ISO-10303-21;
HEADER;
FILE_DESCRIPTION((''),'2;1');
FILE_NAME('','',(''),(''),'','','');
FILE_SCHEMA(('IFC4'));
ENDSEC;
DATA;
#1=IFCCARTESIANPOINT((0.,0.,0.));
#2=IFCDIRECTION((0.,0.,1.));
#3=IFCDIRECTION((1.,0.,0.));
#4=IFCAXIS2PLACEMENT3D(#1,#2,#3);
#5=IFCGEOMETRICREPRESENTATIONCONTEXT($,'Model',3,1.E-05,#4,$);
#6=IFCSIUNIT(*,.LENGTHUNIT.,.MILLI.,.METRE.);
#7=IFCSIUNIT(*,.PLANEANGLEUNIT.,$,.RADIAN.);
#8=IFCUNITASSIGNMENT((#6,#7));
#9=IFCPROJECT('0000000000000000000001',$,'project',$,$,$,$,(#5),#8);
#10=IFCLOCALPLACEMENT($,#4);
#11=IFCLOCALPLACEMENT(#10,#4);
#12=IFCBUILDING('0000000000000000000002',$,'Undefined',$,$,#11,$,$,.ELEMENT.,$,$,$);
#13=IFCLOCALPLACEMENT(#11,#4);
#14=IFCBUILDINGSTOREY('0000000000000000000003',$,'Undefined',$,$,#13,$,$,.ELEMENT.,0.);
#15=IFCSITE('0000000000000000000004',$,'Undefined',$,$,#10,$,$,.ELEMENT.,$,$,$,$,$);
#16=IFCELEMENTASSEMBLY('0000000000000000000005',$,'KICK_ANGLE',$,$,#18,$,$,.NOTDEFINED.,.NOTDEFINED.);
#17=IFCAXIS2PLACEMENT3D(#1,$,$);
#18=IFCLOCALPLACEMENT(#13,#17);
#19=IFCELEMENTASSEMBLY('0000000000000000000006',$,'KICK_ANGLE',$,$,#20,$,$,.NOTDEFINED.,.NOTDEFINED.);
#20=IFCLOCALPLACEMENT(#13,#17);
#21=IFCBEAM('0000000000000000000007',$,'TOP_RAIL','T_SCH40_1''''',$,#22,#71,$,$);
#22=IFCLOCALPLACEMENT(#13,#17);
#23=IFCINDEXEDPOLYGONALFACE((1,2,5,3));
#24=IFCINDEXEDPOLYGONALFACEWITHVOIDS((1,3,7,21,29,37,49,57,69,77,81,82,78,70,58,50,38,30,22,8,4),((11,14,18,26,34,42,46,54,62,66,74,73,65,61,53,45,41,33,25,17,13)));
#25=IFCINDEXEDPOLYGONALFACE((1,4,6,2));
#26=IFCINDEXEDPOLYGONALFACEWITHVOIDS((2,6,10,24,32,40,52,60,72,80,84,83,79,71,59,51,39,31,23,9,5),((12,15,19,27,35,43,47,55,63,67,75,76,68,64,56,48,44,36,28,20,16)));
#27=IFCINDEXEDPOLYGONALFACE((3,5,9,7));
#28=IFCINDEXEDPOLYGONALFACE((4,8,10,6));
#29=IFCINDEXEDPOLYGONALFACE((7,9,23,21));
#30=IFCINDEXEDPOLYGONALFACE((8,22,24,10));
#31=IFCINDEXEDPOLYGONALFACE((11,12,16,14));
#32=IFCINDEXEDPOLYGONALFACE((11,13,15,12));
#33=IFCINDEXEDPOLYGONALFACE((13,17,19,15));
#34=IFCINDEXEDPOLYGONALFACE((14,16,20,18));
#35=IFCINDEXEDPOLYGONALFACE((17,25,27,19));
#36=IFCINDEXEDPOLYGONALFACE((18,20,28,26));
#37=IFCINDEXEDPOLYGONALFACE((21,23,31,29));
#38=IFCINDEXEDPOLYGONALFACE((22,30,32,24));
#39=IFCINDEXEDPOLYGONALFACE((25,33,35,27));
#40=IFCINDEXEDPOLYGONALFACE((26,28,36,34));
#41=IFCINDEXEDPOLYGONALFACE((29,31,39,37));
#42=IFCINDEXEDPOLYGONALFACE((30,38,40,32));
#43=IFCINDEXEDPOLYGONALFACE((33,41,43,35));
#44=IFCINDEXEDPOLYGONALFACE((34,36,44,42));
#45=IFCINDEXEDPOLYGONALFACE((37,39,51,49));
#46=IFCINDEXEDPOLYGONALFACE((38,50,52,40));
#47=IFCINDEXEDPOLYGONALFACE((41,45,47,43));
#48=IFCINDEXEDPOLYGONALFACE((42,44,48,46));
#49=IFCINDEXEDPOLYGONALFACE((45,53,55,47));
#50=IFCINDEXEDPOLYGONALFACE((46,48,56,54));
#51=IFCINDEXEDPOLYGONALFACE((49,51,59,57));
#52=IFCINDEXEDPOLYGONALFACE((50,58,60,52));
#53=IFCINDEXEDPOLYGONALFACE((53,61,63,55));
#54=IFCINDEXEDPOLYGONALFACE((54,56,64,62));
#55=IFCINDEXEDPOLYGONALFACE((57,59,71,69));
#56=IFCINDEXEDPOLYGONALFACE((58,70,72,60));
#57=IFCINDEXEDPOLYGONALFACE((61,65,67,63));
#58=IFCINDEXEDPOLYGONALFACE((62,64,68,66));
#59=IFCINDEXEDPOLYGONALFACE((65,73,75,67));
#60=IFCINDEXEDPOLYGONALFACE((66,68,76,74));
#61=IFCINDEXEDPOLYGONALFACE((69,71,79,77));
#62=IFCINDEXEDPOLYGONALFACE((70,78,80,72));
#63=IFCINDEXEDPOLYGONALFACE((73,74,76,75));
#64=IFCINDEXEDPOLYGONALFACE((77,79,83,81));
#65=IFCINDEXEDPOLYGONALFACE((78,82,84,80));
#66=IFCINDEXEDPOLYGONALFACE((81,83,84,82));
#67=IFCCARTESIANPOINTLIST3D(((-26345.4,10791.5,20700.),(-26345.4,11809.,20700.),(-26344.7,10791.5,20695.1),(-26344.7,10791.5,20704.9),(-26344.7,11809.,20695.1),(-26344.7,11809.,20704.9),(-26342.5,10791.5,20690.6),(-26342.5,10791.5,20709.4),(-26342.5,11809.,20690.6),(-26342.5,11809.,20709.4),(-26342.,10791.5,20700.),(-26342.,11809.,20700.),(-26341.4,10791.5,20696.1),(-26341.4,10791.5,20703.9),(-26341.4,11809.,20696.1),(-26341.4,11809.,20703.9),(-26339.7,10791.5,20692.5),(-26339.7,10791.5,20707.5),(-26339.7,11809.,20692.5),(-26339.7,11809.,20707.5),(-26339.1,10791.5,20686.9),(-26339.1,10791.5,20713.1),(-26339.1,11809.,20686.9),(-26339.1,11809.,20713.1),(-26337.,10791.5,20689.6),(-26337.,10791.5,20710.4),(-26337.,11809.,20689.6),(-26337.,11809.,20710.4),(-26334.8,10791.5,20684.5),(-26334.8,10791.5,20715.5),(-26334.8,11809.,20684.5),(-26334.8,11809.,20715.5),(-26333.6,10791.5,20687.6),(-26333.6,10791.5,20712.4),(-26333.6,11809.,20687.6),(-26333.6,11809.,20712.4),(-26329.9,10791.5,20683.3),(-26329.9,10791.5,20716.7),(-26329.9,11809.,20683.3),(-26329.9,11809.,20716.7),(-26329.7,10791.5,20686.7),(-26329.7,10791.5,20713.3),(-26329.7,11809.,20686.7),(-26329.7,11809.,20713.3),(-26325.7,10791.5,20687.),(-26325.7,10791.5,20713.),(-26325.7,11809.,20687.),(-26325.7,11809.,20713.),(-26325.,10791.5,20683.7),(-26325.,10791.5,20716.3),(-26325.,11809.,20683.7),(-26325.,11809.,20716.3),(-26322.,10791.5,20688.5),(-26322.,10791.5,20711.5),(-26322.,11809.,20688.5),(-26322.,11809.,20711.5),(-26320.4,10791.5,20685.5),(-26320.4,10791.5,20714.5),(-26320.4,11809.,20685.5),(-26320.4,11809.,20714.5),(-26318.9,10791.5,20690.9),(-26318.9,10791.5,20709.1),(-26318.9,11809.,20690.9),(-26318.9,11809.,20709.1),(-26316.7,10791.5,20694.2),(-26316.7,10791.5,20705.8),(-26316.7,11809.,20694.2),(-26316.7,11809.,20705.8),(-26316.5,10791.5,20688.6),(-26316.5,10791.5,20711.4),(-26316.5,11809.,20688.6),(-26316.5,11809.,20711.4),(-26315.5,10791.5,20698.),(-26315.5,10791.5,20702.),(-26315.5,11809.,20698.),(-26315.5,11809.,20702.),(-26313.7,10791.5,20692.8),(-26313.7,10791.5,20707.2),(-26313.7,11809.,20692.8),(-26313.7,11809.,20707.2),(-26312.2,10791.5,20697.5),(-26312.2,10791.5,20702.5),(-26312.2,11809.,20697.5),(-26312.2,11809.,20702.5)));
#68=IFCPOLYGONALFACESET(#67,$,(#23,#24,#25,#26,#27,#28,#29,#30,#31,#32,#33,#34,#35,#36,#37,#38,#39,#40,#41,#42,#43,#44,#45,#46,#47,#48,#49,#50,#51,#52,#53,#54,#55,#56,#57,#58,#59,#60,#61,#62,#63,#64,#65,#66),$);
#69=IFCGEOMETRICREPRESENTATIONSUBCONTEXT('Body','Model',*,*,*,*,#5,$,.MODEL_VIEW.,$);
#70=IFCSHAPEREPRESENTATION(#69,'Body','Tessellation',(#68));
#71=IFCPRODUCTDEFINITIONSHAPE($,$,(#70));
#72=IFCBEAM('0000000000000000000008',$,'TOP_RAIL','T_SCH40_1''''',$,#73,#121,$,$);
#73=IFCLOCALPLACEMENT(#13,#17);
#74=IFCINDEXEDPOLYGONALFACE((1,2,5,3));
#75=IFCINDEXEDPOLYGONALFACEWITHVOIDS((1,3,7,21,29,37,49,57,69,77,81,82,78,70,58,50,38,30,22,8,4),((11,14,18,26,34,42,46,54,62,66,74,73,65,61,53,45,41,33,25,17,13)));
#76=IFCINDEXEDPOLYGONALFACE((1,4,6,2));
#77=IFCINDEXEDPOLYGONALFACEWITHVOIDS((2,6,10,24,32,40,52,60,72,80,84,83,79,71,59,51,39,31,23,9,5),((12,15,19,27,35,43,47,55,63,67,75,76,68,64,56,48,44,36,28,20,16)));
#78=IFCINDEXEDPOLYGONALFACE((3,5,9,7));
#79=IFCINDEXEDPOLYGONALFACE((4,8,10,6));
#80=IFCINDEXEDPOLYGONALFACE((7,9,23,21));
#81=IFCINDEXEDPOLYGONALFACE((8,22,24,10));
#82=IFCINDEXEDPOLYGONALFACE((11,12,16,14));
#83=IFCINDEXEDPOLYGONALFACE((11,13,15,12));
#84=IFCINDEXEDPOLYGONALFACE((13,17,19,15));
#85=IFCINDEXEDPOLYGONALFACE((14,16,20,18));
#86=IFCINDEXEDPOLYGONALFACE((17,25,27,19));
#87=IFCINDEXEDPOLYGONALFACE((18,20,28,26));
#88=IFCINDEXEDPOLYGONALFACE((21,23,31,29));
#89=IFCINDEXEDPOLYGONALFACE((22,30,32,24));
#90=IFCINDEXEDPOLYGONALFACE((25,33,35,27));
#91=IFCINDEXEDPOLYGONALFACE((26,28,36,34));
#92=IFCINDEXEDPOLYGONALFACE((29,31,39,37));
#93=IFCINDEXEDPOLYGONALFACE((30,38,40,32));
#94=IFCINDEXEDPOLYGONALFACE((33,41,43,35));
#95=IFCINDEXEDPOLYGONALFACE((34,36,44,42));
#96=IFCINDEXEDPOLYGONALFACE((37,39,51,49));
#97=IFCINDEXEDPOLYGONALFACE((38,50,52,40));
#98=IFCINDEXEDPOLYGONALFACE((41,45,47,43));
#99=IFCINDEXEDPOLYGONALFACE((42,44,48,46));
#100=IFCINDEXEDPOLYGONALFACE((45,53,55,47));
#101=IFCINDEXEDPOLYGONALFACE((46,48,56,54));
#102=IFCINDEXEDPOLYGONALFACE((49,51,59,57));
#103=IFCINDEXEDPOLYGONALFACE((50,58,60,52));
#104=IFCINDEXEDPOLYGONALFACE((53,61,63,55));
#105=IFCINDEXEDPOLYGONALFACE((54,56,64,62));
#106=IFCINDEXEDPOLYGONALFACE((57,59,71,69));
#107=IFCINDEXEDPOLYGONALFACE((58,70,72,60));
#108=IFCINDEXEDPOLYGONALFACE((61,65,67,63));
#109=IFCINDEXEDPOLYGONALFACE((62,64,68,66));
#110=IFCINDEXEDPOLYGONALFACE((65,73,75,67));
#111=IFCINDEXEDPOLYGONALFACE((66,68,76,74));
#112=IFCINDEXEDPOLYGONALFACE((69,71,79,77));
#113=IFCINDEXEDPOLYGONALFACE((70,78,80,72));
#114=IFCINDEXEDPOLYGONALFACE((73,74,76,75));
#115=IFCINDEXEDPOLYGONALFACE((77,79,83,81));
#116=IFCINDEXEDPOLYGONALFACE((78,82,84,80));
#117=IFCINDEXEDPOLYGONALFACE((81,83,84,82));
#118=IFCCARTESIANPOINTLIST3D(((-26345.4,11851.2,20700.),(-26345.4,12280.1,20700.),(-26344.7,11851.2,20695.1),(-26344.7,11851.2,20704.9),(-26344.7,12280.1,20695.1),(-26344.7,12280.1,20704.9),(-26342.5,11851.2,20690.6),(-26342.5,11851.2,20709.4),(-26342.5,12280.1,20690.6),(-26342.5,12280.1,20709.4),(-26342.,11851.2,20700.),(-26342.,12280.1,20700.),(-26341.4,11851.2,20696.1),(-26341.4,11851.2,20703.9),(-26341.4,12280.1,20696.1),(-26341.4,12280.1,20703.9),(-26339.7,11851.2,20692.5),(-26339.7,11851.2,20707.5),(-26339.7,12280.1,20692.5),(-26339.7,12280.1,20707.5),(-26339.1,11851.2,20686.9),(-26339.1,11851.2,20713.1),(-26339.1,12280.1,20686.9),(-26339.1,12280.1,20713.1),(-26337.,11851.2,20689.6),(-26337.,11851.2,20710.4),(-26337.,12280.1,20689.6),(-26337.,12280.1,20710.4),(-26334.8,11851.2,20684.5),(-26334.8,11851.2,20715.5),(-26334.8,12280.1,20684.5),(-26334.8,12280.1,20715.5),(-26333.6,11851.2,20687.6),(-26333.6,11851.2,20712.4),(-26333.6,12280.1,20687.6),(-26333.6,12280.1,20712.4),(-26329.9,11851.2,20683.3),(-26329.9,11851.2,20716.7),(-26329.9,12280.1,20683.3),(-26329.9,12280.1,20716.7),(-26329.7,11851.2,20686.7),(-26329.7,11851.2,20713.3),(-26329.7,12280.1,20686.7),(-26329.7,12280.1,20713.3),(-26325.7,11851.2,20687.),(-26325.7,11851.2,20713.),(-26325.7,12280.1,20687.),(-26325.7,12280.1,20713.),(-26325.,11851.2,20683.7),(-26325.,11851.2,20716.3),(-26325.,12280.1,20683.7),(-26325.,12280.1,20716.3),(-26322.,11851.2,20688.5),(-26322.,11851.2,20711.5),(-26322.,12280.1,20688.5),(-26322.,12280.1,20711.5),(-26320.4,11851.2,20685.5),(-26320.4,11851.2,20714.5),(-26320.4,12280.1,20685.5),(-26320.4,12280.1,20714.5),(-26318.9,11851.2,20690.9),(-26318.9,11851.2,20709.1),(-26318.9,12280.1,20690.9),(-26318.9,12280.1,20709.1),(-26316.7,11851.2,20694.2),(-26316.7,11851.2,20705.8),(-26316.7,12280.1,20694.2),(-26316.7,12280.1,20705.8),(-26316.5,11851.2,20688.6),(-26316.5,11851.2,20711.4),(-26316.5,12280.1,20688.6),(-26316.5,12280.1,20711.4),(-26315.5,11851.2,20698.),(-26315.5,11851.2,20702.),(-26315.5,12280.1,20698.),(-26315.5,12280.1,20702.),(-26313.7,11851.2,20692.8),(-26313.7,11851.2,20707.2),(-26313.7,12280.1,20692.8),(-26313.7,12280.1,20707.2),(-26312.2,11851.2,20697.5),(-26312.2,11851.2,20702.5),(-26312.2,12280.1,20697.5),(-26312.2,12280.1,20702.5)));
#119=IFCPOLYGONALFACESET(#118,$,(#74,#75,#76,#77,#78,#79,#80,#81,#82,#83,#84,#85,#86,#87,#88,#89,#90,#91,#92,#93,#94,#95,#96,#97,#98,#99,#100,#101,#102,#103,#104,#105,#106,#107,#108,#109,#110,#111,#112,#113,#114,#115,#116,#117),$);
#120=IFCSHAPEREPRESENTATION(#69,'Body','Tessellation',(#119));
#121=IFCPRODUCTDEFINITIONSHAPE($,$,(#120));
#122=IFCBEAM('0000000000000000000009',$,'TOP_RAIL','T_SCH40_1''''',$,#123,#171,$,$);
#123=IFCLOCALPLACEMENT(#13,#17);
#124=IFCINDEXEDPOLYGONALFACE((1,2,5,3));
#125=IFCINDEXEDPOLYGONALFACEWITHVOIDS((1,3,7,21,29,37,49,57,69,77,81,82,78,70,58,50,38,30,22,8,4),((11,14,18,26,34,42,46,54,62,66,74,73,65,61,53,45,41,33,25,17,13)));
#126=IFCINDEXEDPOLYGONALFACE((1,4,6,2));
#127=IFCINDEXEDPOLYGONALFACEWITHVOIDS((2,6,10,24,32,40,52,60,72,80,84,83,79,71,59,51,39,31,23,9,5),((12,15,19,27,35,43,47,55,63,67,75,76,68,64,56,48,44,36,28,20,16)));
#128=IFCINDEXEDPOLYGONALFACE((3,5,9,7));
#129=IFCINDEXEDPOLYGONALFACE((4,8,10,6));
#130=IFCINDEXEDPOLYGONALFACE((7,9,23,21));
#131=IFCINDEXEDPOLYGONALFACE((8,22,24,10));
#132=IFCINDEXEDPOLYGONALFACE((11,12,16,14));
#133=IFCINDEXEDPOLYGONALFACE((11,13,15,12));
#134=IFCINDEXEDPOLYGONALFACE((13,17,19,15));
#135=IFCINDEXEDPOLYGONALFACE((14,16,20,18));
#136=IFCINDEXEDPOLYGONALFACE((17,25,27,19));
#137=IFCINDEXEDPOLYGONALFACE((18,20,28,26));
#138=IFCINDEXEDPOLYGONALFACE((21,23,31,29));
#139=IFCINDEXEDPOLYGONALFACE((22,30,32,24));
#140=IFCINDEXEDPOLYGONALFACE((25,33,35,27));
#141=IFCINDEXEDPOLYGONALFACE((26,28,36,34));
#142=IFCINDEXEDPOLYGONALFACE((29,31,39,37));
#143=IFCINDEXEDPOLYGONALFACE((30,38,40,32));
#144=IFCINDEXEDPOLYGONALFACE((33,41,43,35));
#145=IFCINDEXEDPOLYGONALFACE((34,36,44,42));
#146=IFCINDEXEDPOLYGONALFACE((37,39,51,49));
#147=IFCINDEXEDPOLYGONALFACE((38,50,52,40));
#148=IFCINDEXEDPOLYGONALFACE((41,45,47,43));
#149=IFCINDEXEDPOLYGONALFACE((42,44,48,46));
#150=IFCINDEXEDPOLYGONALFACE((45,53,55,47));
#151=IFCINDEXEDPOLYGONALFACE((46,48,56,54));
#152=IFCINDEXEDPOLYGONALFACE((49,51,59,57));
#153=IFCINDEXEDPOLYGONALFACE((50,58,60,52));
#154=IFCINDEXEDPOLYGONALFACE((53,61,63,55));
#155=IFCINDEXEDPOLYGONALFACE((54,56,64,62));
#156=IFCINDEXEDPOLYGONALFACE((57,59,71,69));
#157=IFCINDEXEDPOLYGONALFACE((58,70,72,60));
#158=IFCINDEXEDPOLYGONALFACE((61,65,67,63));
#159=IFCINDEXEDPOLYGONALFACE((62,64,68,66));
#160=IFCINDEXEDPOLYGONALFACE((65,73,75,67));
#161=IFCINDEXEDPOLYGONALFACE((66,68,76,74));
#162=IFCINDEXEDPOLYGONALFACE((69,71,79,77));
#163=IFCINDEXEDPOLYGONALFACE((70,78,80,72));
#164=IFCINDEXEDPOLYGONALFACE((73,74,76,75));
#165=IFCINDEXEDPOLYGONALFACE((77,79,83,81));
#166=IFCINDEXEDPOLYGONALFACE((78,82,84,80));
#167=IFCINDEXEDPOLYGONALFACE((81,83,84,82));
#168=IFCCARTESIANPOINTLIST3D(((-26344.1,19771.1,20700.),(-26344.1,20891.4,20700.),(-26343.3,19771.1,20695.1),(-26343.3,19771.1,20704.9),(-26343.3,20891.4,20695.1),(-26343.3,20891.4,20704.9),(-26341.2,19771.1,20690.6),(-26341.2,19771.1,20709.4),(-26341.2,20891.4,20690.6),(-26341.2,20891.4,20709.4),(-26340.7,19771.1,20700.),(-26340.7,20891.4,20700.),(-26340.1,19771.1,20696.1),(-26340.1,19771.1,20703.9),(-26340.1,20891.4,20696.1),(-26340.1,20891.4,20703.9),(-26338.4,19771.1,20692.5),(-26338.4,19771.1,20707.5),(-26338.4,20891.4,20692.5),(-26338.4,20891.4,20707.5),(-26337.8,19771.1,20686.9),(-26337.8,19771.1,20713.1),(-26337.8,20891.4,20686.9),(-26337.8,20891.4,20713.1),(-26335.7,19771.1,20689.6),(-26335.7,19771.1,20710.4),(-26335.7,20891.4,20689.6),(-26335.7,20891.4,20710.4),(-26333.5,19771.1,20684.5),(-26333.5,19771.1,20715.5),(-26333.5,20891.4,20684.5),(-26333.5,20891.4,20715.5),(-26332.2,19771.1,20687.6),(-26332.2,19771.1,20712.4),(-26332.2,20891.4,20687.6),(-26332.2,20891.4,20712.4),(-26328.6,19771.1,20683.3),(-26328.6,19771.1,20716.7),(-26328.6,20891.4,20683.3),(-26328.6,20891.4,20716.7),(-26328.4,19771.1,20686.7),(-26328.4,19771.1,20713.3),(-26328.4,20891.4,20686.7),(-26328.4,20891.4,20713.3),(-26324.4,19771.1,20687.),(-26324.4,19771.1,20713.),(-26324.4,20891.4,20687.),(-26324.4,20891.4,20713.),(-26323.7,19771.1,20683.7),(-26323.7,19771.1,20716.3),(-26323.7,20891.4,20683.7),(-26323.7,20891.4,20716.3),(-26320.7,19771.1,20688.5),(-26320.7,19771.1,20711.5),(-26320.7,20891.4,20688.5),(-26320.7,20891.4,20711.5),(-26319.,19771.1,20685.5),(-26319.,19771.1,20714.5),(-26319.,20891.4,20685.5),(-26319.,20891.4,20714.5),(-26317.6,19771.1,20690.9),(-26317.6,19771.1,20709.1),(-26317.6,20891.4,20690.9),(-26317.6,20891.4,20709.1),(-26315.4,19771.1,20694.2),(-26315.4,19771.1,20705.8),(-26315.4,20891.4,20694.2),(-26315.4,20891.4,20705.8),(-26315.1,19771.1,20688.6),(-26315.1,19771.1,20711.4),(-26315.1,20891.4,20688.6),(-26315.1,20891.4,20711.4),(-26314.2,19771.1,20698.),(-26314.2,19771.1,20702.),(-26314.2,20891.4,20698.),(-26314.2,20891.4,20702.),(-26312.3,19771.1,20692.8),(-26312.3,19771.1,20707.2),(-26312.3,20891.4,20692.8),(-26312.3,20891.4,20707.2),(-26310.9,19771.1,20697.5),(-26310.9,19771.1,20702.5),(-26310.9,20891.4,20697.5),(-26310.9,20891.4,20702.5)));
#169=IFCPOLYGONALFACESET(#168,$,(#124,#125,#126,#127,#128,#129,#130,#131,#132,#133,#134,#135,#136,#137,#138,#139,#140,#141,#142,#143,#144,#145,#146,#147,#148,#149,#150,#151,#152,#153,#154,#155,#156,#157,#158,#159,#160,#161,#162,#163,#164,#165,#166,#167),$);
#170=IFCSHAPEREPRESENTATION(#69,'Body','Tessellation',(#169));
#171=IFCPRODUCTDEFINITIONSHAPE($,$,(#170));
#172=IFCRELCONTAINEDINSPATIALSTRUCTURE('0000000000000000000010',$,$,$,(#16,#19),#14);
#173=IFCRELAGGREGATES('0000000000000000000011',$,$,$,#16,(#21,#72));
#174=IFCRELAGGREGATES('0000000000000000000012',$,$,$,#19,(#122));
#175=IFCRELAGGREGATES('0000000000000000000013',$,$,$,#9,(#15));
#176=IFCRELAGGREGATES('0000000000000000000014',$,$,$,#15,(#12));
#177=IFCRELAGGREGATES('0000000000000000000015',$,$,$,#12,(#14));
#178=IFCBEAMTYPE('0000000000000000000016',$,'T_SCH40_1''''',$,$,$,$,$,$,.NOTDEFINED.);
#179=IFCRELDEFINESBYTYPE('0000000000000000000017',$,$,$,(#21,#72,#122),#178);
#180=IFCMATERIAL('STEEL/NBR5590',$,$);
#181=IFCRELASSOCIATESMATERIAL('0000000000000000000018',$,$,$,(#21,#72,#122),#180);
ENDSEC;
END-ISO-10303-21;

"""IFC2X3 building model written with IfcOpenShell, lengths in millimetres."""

from ifc_helpers import new_model, si_unit, frame, origin_with_axes, origin_2d_with_axis, place, context, subcontext, project, spatial, hollow_circle, extrude, material, type_object, element, aggregate, save


model = new_model("IFC2X3")

# Units and contexts
model_context = context("Model", 3, precision=1e-05, world=origin_with_axes())
body_context = subcontext(model_context, "Body", "Model", "MODEL_VIEW")
ifc_project = project(units=[si_unit("LENGTHUNIT", "METRE", prefix="MILLI"), si_unit("PLANEANGLEUNIT", "RADIAN")], contexts=[model_context])

# Site, building, storey
site_placement = place(None, origin_with_axes())
site = spatial("IfcSite", under=ifc_project, at=site_placement, Name="Undefined", CompositionType="ELEMENT")
building_placement = place(site_placement, origin_with_axes())
building = spatial("IfcBuilding", under=site, at=building_placement, Name="Undefined", CompositionType="ELEMENT")
storey_placement = place(building_placement, origin_with_axes())
storey = spatial("IfcBuildingStorey", under=building, at=storey_placement, Name="Undefined", CompositionType="ELEMENT", Elevation=0.0)

# Element assembly
assembly_1_placement = place(storey_placement, origin_with_axes())
assembly_1 = element("IfcElementAssembly", 1, at=assembly_1_placement, inside=storey, Name="KICK_ANGLE", AssemblyPlace="NOTDEFINED", PredefinedType="NOTDEFINED")
ifc_material_1 = material(Name="STEEL/NBR5590")

# Element assembly
assembly_2_placement = place(storey_placement, origin_with_axes())
assembly_2 = element("IfcElementAssembly", 2, at=assembly_2_placement, inside=storey, Name="KICK_ANGLE", AssemblyPlace="NOTDEFINED", PredefinedType="NOTDEFINED")

# Beams
beam_type_1 = type_object("IfcBeamType", Name="T_SCH40_1''", PredefinedType="NOTDEFINED")
beam_1_placement = place(assembly_1_placement, frame((-26328.7, 11809.0, 20700.0), z_axis=(0.0, 0.0, 1.0), x_axis=(0.0, -1.0, 0.0)))
beam_1 = element("IfcBeam", 3, at=beam_1_placement, type_object=beam_type_1, material=ifc_material_1, Name="TOP_RAIL", Description="T_SCH40_1''", context=body_context, shape_type="SweptSolid", body=[
    extrude(hollow_circle(Radius=16.7, WallThickness=3.4, at=origin_2d_with_axis()), frame((1017.5, 0.0, 0.0), z_axis=(-1.0, 0.0, 0.0), x_axis=(0.0, -1.0, 0.0)), (0.0, 0.0, 1.0), 1017.5),
])
beam_2_placement = place(assembly_1_placement, frame((-26328.7, 12280.1, 20700.0), z_axis=(0.0, 0.0, 1.0), x_axis=(0.0, -1.0, 0.0)))
beam_2 = element("IfcBeam", 4, at=beam_2_placement, type_object=beam_type_1, material=ifc_material_1, Name="TOP_RAIL", Description="T_SCH40_1''", context=body_context, shape_type="SweptSolid", body=[
    extrude(hollow_circle(Radius=16.7, WallThickness=3.4, at=origin_2d_with_axis()), frame((428.9, 0.0, 0.0), z_axis=(-1.0, 0.0, 0.0), x_axis=(0.0, -1.0, 0.0)), (0.0, 0.0, 1.0), 428.9),
])
beam_3_placement = place(assembly_2_placement, frame((-26327.4, 20891.4, 20700.0), z_axis=(0.0, 0.0, 1.0), x_axis=(0.0, -1.0, 0.0)))
beam_3 = element("IfcBeam", 5, at=beam_3_placement, type_object=beam_type_1, material=ifc_material_1, Name="TOP_RAIL", Description="T_SCH40_1''", context=body_context, shape_type="SweptSolid", body=[
    extrude(hollow_circle(Radius=16.7, WallThickness=3.4, at=origin_2d_with_axis()), frame((1120.3, 0.0, 0.0), z_axis=(-1.0, 0.0, 0.0), x_axis=(0.0, -1.0, 0.0)), (0.0, 0.0, 1.0), 1120.3),
])

aggregate(assembly_1, [beam_1, beam_2])
aggregate(assembly_2, [beam_3])

save(model, "model.ifc")
